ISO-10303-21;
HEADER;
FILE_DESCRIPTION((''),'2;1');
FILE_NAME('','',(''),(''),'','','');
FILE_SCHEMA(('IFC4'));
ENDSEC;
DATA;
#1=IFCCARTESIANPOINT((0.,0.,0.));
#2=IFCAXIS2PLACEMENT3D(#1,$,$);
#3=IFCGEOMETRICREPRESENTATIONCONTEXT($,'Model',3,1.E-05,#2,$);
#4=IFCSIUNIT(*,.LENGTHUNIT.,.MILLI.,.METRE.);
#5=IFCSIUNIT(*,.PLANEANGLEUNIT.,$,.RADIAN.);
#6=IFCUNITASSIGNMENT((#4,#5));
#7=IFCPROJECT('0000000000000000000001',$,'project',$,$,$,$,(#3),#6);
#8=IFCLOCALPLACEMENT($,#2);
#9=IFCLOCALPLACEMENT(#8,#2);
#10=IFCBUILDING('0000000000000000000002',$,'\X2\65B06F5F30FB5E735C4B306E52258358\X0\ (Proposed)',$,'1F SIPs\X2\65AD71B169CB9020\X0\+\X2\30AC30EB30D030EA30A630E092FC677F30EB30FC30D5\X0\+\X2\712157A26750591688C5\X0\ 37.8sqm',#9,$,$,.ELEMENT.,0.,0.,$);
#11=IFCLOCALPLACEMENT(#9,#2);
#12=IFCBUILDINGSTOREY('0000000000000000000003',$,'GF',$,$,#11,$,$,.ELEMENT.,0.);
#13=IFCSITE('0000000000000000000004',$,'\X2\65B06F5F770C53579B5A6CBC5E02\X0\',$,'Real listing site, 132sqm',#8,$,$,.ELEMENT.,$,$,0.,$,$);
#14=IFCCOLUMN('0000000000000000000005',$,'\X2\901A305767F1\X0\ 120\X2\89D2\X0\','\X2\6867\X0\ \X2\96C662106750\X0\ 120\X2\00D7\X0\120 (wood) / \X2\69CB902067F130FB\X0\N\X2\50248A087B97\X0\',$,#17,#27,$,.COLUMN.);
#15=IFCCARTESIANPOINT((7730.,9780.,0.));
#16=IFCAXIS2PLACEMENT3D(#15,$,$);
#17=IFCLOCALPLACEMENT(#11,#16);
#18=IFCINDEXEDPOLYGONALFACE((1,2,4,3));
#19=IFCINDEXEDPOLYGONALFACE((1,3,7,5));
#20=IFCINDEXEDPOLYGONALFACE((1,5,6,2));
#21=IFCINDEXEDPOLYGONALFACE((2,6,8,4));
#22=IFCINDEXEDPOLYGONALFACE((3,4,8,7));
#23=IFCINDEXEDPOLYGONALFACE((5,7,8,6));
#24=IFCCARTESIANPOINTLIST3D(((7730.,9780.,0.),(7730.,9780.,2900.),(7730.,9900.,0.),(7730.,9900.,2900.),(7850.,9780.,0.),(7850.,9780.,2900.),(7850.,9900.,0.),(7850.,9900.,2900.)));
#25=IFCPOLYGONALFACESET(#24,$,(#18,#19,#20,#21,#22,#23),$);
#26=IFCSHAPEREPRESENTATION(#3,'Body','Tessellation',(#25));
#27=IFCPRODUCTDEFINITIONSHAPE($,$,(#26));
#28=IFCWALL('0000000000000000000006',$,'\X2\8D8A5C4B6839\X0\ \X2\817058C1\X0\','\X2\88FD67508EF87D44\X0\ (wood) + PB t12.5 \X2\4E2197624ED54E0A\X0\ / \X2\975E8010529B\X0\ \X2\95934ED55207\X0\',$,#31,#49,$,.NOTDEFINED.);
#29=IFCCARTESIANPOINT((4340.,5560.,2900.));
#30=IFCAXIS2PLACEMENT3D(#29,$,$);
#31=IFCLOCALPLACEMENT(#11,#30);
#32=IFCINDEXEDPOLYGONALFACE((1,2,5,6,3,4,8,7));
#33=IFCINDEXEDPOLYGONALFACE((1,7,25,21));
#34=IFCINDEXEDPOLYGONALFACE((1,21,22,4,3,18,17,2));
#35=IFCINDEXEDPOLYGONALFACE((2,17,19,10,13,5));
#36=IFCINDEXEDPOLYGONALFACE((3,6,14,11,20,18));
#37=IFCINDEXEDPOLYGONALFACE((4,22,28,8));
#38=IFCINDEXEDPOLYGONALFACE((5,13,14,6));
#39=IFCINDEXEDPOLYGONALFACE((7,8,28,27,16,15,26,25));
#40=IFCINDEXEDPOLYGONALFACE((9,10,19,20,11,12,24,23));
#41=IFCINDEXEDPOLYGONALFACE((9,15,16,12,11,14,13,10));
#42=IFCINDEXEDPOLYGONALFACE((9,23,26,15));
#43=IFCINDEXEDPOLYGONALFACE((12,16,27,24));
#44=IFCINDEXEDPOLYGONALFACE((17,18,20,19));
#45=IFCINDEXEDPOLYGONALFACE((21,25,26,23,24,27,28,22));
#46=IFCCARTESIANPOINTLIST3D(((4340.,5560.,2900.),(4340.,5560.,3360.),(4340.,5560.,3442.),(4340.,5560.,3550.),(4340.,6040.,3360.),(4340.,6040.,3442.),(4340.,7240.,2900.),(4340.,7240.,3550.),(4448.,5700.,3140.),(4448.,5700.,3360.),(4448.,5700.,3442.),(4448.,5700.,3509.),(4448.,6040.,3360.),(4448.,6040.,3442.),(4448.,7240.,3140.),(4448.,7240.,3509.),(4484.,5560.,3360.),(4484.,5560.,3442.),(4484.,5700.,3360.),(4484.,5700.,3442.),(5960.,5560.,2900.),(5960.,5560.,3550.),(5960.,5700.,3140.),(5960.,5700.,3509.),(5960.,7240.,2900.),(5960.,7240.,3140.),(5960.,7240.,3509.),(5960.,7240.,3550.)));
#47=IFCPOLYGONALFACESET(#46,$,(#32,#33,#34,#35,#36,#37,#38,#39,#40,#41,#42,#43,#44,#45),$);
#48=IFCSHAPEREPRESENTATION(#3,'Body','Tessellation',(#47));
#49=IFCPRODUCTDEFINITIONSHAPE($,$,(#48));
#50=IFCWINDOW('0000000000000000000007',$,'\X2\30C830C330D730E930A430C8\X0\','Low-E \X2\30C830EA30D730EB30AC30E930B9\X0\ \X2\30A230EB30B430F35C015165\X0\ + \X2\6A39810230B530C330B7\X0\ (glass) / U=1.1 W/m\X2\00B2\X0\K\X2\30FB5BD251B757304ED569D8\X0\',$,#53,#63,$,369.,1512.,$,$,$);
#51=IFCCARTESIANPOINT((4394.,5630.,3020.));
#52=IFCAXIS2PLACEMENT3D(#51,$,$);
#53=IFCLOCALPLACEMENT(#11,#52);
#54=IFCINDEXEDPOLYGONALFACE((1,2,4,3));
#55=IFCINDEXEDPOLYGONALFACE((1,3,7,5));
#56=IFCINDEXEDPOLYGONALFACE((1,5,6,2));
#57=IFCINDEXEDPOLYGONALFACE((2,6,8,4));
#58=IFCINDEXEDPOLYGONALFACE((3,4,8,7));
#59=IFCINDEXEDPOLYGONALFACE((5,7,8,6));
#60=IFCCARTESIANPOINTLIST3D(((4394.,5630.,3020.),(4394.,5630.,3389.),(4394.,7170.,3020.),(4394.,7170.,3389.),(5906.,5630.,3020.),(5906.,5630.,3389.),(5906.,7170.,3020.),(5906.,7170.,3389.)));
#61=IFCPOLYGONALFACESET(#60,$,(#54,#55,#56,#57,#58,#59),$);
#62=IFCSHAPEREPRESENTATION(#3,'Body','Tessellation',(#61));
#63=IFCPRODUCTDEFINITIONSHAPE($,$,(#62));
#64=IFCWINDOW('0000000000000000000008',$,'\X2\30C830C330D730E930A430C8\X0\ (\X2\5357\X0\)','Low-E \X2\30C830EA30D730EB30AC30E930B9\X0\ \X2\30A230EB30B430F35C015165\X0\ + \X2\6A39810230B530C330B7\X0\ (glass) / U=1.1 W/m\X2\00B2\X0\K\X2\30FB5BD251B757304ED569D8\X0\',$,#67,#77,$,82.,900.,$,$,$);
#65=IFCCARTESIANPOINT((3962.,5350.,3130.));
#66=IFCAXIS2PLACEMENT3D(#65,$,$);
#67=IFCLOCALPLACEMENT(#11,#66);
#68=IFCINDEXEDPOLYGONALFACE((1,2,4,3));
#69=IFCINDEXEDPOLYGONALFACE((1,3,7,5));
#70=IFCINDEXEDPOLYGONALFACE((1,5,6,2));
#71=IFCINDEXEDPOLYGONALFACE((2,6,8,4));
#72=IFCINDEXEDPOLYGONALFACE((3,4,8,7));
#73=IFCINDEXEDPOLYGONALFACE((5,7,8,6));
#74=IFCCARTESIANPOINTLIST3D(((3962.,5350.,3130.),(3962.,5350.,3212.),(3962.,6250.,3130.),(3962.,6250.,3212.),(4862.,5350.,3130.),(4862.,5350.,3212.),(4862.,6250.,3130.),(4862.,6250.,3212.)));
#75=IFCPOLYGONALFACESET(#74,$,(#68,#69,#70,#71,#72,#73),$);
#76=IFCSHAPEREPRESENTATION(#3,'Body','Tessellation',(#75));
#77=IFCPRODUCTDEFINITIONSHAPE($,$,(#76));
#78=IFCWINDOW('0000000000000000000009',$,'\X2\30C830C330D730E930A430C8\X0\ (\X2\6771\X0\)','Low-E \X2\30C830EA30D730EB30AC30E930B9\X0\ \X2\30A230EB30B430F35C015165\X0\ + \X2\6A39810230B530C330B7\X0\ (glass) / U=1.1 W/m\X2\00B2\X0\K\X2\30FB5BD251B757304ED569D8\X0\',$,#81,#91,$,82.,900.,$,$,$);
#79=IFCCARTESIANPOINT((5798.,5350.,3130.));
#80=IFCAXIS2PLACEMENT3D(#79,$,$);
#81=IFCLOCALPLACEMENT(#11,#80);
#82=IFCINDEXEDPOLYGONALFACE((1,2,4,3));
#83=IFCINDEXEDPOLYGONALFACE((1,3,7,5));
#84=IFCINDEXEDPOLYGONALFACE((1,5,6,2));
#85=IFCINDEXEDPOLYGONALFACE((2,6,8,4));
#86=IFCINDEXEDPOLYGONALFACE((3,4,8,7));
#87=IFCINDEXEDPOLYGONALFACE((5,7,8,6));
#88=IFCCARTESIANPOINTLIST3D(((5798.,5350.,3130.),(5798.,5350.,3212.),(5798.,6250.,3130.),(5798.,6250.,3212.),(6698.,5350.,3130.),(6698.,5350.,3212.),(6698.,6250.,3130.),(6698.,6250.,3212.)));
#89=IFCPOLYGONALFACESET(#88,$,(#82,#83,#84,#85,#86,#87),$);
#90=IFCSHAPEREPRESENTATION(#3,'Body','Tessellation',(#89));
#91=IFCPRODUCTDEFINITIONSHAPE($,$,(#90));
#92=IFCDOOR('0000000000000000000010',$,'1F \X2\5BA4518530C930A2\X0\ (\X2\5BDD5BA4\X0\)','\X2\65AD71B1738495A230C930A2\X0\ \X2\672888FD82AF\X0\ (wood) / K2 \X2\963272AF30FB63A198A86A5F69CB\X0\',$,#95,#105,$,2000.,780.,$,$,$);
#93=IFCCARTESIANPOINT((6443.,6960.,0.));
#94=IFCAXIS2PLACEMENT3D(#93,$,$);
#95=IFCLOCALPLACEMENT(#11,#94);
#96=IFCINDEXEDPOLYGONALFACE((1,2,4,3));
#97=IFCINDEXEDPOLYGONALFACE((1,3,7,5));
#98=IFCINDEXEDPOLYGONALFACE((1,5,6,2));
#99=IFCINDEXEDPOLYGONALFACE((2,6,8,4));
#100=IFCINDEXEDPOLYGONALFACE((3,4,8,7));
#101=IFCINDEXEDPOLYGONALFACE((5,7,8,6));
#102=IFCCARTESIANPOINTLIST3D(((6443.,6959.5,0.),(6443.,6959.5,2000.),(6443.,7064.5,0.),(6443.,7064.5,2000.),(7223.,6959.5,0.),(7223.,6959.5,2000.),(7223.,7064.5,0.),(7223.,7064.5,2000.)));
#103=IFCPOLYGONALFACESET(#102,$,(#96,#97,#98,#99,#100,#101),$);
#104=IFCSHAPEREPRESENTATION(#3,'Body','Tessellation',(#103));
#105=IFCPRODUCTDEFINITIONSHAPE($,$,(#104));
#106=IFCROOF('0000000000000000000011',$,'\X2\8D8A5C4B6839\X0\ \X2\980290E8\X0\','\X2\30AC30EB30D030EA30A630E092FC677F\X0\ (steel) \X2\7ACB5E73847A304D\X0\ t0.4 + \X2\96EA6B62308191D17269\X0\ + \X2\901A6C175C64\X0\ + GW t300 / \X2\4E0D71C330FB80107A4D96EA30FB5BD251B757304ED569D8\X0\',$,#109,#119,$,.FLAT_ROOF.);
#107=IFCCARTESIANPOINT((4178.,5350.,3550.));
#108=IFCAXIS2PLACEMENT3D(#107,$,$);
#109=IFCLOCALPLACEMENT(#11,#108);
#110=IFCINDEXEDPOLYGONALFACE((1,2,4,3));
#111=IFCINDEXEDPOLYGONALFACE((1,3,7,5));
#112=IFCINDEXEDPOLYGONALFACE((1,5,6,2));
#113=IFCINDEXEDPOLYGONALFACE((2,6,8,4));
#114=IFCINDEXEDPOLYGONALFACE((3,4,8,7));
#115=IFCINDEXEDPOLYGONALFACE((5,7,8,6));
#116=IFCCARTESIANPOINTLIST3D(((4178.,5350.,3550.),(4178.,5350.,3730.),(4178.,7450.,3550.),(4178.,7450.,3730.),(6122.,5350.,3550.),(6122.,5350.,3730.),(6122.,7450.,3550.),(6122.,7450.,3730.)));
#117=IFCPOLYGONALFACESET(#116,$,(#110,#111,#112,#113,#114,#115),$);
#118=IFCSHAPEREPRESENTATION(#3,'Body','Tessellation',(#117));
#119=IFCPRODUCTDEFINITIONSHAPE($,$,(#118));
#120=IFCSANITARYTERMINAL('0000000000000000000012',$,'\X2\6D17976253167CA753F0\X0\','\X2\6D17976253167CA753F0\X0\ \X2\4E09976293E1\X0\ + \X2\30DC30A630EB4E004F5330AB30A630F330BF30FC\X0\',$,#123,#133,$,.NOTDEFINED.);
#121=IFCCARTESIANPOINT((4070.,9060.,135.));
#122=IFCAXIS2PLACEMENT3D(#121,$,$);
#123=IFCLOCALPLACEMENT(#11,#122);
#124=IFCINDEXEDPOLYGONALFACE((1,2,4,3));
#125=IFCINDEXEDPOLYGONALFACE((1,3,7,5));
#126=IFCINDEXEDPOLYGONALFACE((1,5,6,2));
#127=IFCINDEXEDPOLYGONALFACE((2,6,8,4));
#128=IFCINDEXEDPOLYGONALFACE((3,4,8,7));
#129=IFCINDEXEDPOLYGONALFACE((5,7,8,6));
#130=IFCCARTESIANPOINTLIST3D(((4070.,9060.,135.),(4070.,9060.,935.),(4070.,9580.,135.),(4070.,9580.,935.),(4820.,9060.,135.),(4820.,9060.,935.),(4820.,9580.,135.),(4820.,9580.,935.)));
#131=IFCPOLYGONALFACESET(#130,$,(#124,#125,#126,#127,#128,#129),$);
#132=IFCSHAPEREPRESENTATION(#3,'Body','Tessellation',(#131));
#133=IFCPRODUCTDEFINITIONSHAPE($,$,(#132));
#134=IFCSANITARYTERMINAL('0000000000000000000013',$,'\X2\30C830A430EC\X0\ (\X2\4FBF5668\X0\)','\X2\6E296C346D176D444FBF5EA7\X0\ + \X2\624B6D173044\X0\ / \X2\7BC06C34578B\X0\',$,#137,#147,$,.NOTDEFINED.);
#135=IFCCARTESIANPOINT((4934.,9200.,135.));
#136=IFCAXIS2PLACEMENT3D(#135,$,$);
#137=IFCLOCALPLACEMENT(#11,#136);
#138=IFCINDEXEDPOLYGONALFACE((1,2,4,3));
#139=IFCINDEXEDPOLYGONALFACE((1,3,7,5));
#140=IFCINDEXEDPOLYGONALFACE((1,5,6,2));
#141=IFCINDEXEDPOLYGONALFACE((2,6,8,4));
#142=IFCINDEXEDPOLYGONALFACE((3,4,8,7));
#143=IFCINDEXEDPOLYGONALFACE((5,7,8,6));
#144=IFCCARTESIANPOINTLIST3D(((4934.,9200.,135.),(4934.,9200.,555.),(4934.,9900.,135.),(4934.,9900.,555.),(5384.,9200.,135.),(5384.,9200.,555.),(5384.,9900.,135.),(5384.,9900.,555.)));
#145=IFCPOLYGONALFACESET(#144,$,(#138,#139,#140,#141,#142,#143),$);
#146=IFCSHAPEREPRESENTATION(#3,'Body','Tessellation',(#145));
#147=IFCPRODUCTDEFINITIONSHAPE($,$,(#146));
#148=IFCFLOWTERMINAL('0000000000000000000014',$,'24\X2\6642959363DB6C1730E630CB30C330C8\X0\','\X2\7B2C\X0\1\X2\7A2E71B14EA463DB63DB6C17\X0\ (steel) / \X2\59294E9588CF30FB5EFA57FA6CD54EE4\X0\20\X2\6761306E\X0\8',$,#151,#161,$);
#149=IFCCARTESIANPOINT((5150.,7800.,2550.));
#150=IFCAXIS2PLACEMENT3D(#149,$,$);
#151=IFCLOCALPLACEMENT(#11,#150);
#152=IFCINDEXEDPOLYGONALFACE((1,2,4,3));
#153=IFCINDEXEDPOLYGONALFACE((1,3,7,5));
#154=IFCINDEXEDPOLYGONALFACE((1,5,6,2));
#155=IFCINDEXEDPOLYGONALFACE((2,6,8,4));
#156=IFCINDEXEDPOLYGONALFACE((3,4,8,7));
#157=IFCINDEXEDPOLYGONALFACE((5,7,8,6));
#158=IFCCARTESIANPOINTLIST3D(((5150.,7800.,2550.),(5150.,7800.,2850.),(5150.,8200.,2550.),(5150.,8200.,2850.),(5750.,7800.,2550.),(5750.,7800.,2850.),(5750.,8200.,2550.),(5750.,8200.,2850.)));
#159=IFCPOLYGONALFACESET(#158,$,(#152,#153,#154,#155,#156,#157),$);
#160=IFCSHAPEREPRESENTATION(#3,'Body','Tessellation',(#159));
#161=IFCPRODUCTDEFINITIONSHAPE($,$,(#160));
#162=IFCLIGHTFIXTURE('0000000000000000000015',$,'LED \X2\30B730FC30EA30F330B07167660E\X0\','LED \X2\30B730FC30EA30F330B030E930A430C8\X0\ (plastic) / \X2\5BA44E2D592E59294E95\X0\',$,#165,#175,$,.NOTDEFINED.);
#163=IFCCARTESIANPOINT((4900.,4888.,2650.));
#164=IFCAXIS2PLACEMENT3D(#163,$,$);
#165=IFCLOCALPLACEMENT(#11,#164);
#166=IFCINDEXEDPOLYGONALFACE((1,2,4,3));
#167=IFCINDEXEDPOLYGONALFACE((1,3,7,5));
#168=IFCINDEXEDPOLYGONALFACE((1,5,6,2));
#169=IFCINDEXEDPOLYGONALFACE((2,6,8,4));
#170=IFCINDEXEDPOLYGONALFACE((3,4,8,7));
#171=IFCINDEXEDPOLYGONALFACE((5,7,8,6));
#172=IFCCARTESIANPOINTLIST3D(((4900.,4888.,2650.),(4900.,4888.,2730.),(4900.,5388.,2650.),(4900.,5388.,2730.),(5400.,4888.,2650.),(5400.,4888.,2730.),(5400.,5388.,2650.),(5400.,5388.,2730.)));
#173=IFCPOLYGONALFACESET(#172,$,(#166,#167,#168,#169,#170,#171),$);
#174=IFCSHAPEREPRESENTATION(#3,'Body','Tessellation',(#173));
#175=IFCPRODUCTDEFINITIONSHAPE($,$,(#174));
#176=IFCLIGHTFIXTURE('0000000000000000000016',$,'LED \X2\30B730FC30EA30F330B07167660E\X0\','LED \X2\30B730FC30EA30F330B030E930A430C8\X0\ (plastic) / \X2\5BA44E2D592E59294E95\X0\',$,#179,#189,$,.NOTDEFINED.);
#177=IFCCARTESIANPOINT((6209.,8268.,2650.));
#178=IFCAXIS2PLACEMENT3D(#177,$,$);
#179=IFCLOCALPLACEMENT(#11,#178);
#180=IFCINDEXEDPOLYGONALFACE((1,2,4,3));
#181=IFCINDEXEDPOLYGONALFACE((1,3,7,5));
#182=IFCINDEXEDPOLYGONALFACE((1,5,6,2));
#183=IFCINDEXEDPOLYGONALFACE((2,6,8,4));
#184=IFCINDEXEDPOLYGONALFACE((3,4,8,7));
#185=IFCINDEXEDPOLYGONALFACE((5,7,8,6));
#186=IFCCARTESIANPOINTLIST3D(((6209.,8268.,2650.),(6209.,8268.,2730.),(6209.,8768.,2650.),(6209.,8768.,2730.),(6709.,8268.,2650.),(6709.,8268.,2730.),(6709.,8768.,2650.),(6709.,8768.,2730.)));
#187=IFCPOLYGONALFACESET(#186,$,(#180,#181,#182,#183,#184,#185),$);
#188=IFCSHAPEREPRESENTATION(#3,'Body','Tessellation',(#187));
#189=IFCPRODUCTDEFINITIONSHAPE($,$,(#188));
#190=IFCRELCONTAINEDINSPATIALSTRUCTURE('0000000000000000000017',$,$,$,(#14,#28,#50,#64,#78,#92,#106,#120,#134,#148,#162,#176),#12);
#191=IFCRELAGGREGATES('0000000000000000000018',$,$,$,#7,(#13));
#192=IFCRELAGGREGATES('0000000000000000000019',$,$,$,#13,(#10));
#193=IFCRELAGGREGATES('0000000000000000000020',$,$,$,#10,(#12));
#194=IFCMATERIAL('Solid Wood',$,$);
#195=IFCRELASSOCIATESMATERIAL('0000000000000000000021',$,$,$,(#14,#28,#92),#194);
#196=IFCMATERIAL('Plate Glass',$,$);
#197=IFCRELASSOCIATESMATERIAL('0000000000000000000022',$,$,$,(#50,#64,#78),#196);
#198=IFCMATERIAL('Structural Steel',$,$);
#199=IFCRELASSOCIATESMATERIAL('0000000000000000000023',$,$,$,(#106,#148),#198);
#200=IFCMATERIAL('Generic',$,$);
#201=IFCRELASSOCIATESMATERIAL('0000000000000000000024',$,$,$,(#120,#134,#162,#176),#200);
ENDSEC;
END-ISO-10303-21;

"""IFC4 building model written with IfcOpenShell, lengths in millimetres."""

from ifc_helpers import new_model, si_unit, frame, frame_2d, origin, place, context, project, spatial, rectangle, extrude, material, element, fill, save


model = new_model("IFC4")

# Units and contexts
model_context = context("Model", 3, precision=1e-05, world=origin())
ifc_project = project(units=[si_unit("LENGTHUNIT", "METRE", prefix="MILLI"), si_unit("PLANEANGLEUNIT", "RADIAN")], contexts=[model_context])

# Site, building, storey
site_placement = place(None, origin())
site = spatial("IfcSite", under=ifc_project, at=site_placement, Name="新潟県南魚沼市", ObjectType="Real listing site, 132sqm", CompositionType="ELEMENT", RefElevation=0.0)
building_placement = place(site_placement, origin())
building = spatial("IfcBuilding", under=site, at=building_placement, Name="新潟・平屋の別荘 (Proposed)", ObjectType="1F SIPs断熱構造+ガルバリウム鋼板ルーフ+無垢材外装 37.8sqm", CompositionType="ELEMENT", ElevationOfRefHeight=0.0, ElevationOfTerrain=0.0)
storey_placement = place(building_placement, origin())
storey = spatial("IfcBuildingStorey", under=building, at=storey_placement, Name="GF", CompositionType="ELEMENT", Elevation=0.0)

# Column
ifc_material_1 = material(Name="Solid Wood")
column_1_placement = place(storey_placement, frame((7730.0, 9780.0, 0.0)))
element("IfcColumn", 1, at=column_1_placement, inside=storey, material=ifc_material_1, Name="通し柱 120角", Description="桧 集成材 120×120 (wood) / 構造柱・N値計算", PredefinedType="COLUMN", context=model_context, shape_type="SweptSolid", body=[
    extrude(rectangle(XDim=120.0, YDim=120.0, at=frame_2d((60.0, 60.0))), frame((7730.0, 9780.0, 0.0)), (0.0, 0.0, 1.0), 2900.0),
])

# Wall, openings, windows
wall_1_placement = place(storey_placement, frame((4340.0, 5560.0, 2900.0)))
wall_1 = element("IfcWall", 2, at=wall_1_placement, inside=storey, material=ifc_material_1, Name="越屋根 腰壁", Description="製材軸組 (wood) + PB t12.5 両面仕上 / 非耐力 間仕切", PredefinedType="NOTDEFINED", context=model_context, shape_type="SweptSolid", body=[
    extrude(rectangle(XDim=1620.0, YDim=1680.0, at=frame_2d((810.0, 840.0))), frame((4340.0, 5560.0, 2900.0)), (0.0, 0.0, 1.0), 650.0),
])
opening_1_placement = place(storey_placement, frame((4394.0, 5630.0, 3020.0)))
opening_1 = element("IfcOpeningElement", 3, at=opening_1_placement, cuts=wall_1, PredefinedType="NOTDEFINED", context=model_context, shape_type="SweptSolid", body=[
    extrude(rectangle(XDim=1512.0, YDim=1540.0, at=frame_2d((756.0, 770.0))), frame((4394.0, 5630.0, 3020.0)), (0.0, 0.0, 1.0), 369.0),
])
opening_2_placement = place(storey_placement, frame((3962.0, 5350.0, 3130.0)))
opening_2 = element("IfcOpeningElement", 4, at=opening_2_placement, cuts=wall_1, PredefinedType="NOTDEFINED", context=model_context, shape_type="SweptSolid", body=[
    extrude(rectangle(XDim=900.0, YDim=900.0, at=frame_2d((450.0, 450.0))), frame((3962.0, 5350.0, 3130.0)), (0.0, 0.0, 1.0), 82.0),
])
opening_3_placement = place(storey_placement, frame((5798.0, 5350.0, 3130.0)))
opening_3 = element("IfcOpeningElement", 5, at=opening_3_placement, cuts=wall_1, PredefinedType="NOTDEFINED", context=model_context, shape_type="SweptSolid", body=[
    extrude(rectangle(XDim=900.0, YDim=900.0, at=frame_2d((450.0, 450.0))), frame((5798.0, 5350.0, 3130.0)), (0.0, 0.0, 1.0), 82.0),
])
ifc_material_2 = material(Name="Plate Glass")
window_1_placement = place(storey_placement, frame((4394.0, 5630.0, 3020.0)))
window_1 = element("IfcWindow", 6, at=window_1_placement, inside=storey, material=ifc_material_2, Name="トップライト", Description="Low-E トリプルガラス アルゴン封入 + 樹脂サッシ (glass) / U=1.1 W/m²K・寒冷地仕様", OverallHeight=369.0, OverallWidth=1512.0, context=model_context, shape_type="SweptSolid", body=[
    extrude(rectangle(XDim=1512.0, YDim=1540.0, at=frame_2d((756.0, 770.0))), frame((4394.0, 5630.0, 3020.0)), (0.0, 0.0, 1.0), 369.0),
])
fill(opening_1, window_1)
window_2_placement = place(storey_placement, frame((3962.0, 5350.0, 3130.0)))
window_2 = element("IfcWindow", 7, at=window_2_placement, inside=storey, material=ifc_material_2, Name="トップライト (南)", Description="Low-E トリプルガラス アルゴン封入 + 樹脂サッシ (glass) / U=1.1 W/m²K・寒冷地仕様", OverallHeight=82.0, OverallWidth=900.0, context=model_context, shape_type="SweptSolid", body=[
    extrude(rectangle(XDim=900.0, YDim=900.0, at=frame_2d((450.0, 450.0))), frame((3962.0, 5350.0, 3130.0)), (0.0, 0.0, 1.0), 82.0),
])
fill(opening_2, window_2)
window_3_placement = place(storey_placement, frame((5798.0, 5350.0, 3130.0)))
window_3 = element("IfcWindow", 8, at=window_3_placement, inside=storey, material=ifc_material_2, Name="トップライト (東)", Description="Low-E トリプルガラス アルゴン封入 + 樹脂サッシ (glass) / U=1.1 W/m²K・寒冷地仕様", OverallHeight=82.0, OverallWidth=900.0, context=model_context, shape_type="SweptSolid", body=[
    extrude(rectangle(XDim=900.0, YDim=900.0, at=frame_2d((450.0, 450.0))), frame((5798.0, 5350.0, 3130.0)), (0.0, 0.0, 1.0), 82.0),
])
fill(opening_3, window_3)

# Door
door_placement = place(storey_placement, frame((6443.0, 6960.0, 0.0)))
element("IfcDoor", 9, at=door_placement, inside=storey, material=ifc_material_1, Name="1F 室内ドア (寝室)", Description="断熱玄関ドア 木製芯 (wood) / K2 防犯・採風機構", OverallHeight=2000.0, OverallWidth=780.0, context=model_context, shape_type="SweptSolid", body=[
    extrude(rectangle(XDim=780.0, YDim=105.0, at=frame_2d((390.0, 52.0))), frame((6443.0, 6960.0, 0.0)), (0.0, 0.0, 1.0), 2000.0),
])

# Roof
ifc_material_3 = material(Name="Structural Steel")
roof_placement = place(storey_placement, frame((4178.0, 5350.0, 3550.0)))
element("IfcRoof", 10, at=roof_placement, inside=storey, material=ifc_material_3, Name="越屋根 頂部", Description="ガルバリウム鋼板 (steel) 立平葺き t0.4 + 雪止め金物 + 通気層 + GW t300 / 不燃・耐積雪・寒冷地仕様", PredefinedType="FLAT_ROOF", context=model_context, shape_type="SweptSolid", body=[
    extrude(rectangle(XDim=1944.0, YDim=2100.0, at=frame_2d((972.0, 1050.0))), frame((4178.0, 5350.0, 3550.0)), (0.0, 0.0, 1.0), 180.0),
])

# Sanitary terminals
ifc_material_4 = material(Name="Generic")
sanitary_terminal_1_placement = place(storey_placement, frame((4070.0, 9060.0, 135.0)))
element("IfcSanitaryTerminal", 11, at=sanitary_terminal_1_placement, inside=storey, material=ifc_material_4, Name="洗面化粧台", Description="洗面化粧台 三面鏡 + ボウル一体カウンター", PredefinedType="NOTDEFINED", context=model_context, shape_type="SweptSolid", body=[
    extrude(rectangle(XDim=750.0, YDim=520.0, at=frame_2d((375.0, 260.0))), frame((4070.0, 9060.0, 135.0)), (0.0, 0.0, 1.0), 800.0),
])
sanitary_terminal_2_placement = place(storey_placement, frame((4934.0, 9200.0, 135.0)))
element("IfcSanitaryTerminal", 12, at=sanitary_terminal_2_placement, inside=storey, material=ifc_material_4, Name="トイレ (便器)", Description="温水洗浄便座 + 手洗い / 節水型", PredefinedType="NOTDEFINED", context=model_context, shape_type="SweptSolid", body=[
    extrude(rectangle(XDim=450.0, YDim=700.0, at=frame_2d((225.0, 350.0))), frame((4934.0, 9200.0, 135.0)), (0.0, 0.0, 1.0), 420.0),
])

# Flow terminal
flow_terminal_placement = place(storey_placement, frame((5150.0, 7800.0, 2550.0)))
element("IfcFlowTerminal", 13, at=flow_terminal_placement, inside=storey, material=ifc_material_3, Name="24時間換気ユニット", Description="第1種熱交換換気 (steel) / 天井裏・建基法令20条の8", context=model_context, shape_type="SweptSolid", body=[
    extrude(rectangle(XDim=600.0, YDim=400.0, at=frame_2d((300.0, 200.0))), frame((5150.0, 7800.0, 2550.0)), (0.0, 0.0, 1.0), 300.0),
])

# Light fixtures
light_fixture_1_placement = place(storey_placement, frame((4900.0, 4888.0, 2650.0)))
element("IfcLightFixture", 14, at=light_fixture_1_placement, inside=storey, material=ifc_material_4, Name="LED シーリング照明", Description="LED シーリングライト (plastic) / 室中央天井", PredefinedType="NOTDEFINED", context=model_context, shape_type="SweptSolid", body=[
    extrude(rectangle(XDim=500.0, YDim=500.0, at=frame_2d((250.0, 250.0))), frame((4900.0, 4888.0, 2650.0)), (0.0, 0.0, 1.0), 80.0),
])
light_fixture_2_placement = place(storey_placement, frame((6209.0, 8268.0, 2650.0)))
element("IfcLightFixture", 15, at=light_fixture_2_placement, inside=storey, material=ifc_material_4, Name="LED シーリング照明", Description="LED シーリングライト (plastic) / 室中央天井", PredefinedType="NOTDEFINED", context=model_context, shape_type="SweptSolid", body=[
    extrude(rectangle(XDim=500.0, YDim=500.0, at=frame_2d((250.0, 250.0))), frame((6209.0, 8268.0, 2650.0)), (0.0, 0.0, 1.0), 80.0),
])

save(model, "model.ifc")
